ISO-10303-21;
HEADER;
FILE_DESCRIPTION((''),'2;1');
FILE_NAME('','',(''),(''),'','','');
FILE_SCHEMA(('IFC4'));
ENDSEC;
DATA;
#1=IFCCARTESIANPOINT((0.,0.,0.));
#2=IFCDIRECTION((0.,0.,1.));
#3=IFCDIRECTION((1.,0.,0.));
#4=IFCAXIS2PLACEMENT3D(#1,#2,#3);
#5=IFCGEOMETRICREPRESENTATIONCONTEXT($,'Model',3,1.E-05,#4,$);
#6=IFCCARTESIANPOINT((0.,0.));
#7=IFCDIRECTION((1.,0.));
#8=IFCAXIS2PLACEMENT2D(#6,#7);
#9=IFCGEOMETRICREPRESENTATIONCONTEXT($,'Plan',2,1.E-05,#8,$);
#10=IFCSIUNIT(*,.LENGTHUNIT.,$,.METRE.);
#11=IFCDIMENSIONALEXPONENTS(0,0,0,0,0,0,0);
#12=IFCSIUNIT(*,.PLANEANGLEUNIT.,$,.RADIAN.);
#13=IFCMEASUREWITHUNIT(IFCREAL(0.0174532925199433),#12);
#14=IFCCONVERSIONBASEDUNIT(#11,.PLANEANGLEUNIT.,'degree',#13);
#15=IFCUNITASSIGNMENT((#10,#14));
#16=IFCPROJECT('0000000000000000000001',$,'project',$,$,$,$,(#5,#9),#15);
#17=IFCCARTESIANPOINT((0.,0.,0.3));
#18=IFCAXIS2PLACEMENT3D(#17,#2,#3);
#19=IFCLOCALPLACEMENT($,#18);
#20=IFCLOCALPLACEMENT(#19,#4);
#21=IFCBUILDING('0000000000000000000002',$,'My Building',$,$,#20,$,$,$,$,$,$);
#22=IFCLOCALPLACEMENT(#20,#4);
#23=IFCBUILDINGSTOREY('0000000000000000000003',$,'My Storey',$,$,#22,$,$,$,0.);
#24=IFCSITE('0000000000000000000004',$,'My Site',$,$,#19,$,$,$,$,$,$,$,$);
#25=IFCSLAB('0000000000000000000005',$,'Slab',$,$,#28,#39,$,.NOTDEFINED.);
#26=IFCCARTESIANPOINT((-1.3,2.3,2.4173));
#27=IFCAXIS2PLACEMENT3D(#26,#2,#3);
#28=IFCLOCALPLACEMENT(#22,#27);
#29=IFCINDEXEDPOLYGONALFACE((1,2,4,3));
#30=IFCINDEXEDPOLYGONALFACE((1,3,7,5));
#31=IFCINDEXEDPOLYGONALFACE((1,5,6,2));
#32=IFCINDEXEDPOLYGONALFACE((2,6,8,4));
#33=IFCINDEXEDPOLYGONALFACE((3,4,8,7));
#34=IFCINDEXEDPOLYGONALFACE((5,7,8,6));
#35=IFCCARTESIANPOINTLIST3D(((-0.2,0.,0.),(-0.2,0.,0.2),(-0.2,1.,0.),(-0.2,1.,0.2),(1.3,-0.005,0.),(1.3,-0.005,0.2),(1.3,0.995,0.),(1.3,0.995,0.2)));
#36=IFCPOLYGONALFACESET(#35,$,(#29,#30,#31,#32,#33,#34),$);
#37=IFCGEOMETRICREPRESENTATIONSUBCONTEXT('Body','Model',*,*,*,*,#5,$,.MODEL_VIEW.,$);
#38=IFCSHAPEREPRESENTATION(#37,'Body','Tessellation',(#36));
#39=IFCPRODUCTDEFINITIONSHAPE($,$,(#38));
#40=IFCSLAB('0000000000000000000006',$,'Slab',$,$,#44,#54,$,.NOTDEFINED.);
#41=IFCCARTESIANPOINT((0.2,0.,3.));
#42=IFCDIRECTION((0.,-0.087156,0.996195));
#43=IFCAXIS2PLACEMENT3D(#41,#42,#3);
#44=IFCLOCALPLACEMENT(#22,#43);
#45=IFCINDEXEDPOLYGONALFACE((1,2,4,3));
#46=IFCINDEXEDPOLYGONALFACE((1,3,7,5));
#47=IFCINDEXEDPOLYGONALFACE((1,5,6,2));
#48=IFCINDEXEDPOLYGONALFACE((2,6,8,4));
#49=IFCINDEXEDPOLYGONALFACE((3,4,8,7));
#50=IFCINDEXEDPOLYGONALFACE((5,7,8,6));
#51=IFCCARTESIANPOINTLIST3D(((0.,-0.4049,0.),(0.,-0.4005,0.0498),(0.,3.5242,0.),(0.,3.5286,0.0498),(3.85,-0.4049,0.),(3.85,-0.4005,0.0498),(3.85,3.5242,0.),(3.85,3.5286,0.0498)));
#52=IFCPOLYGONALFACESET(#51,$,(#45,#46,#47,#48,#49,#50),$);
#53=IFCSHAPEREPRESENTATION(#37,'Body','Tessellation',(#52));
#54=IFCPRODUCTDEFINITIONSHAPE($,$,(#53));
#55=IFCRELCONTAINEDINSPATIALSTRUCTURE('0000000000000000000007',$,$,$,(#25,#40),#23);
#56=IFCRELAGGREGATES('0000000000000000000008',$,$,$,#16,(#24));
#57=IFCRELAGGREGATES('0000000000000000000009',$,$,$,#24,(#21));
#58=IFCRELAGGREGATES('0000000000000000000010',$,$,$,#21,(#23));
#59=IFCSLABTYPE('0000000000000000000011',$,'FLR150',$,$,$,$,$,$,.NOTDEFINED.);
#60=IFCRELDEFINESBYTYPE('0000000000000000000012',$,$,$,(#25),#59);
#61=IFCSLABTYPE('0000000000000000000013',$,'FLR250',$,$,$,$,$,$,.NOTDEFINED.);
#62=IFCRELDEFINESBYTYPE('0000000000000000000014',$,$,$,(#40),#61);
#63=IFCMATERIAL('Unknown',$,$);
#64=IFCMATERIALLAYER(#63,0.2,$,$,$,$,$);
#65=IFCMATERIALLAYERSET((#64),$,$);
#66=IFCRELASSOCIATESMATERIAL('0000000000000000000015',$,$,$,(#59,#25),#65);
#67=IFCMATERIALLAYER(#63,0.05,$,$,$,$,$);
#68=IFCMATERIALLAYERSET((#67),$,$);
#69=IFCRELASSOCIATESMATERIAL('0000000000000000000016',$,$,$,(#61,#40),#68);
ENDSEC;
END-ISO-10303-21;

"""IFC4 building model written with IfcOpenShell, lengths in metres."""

from ifc_helpers import new_model, entity, si_unit, converted_unit, frame, origin_with_axes, origin_2d_with_axis, place, context, subcontext, project, spatial, line, indexed_curve, outline, extrude, material, layer, layer_set, layer_usage, type_object, element, save


model = new_model("IFC4")

# Units and contexts
model_context = context("Model", 3, precision=1e-05, world=origin_with_axes())
plan_context = context("Plan", 2, precision=1e-05, world=origin_2d_with_axis())
body_context = subcontext(model_context, "Body", "Model", "MODEL_VIEW")
ifc_project = project(units=[si_unit("LENGTHUNIT", "METRE"), converted_unit("PLANEANGLEUNIT", "degree", entity("IfcReal", 0.0174532925199433), si_unit("PLANEANGLEUNIT", "RADIAN"), dimensions=[0, 0, 0, 0, 0, 0, 0])], contexts=[model_context, plan_context])

# Site, building, storey
site_placement = place(None, frame((0.0, 0.0, 0.3), z_axis=(0.0, 0.0, 1.0), x_axis=(1.0, 0.0, 0.0)))
site = spatial("IfcSite", under=ifc_project, at=site_placement, Name="My Site")
building_placement = place(site_placement, origin_with_axes())
building = spatial("IfcBuilding", under=site, at=building_placement, Name="My Building")
storey_placement = place(building_placement, origin_with_axes())
storey = spatial("IfcBuildingStorey", under=building, at=storey_placement, Name="My Storey", Elevation=0.0)

# Shared definitions
ifc_material = material(Name="Unknown")

# Slabs
ifc_layer_1 = layer(ifc_material, 0.2)
ifc_layer_set_1 = layer_set([ifc_layer_1])
slab_type_1 = type_object("IfcSlabType", Name="FLR150", PredefinedType="NOTDEFINED", material=ifc_layer_set_1)
ifc_layer_usage_1 = layer_usage(ifc_layer_set_1, "AXIS3", "POSITIVE", 0.0)
slab_1_placement = place(storey_placement, frame((-1.3, 2.3, 2.4173), z_axis=(0.0, 0.0, 1.0), x_axis=(1.0, 0.0, 0.0)))
element("IfcSlab", 1, at=slab_1_placement, inside=storey, type_object=slab_type_1, material=ifc_layer_usage_1, Name="Slab", PredefinedType="NOTDEFINED", context=body_context, shape_type="SweptSolid", body=[
    extrude(outline(indexed_curve([(-0.2, 1.0), (-0.2, 0.0), (1.3, -0.005), (1.3, 0.995)], segments=[line(3, 2), line(2, 1), line(1, 4), line(4, 3)], self_intersect=False)), None, (0.0, 0.0, 1.0), 0.2),
])
ifc_layer_2 = layer(ifc_material, 0.05)
ifc_layer_set_2 = layer_set([ifc_layer_2])
ifc_layer_usage_2 = layer_usage(ifc_layer_set_2, "AXIS3", "POSITIVE", 0.0)
slab_type_2 = type_object("IfcSlabType", Name="FLR250", PredefinedType="NOTDEFINED", material=ifc_layer_set_2)
slab_2_placement = place(storey_placement, frame((0.2, 0.0, 3.0), z_axis=(0.0, -0.087156, 0.996195), x_axis=(1.0, 0.0, 0.0)))
element("IfcSlab", 2, at=slab_2_placement, inside=storey, type_object=slab_type_2, material=ifc_layer_usage_2, Name="Slab", PredefinedType="NOTDEFINED", context=body_context, shape_type="SweptSolid", body=[
    extrude(outline(indexed_curve([(0.0, 3.5242), (3.85, 3.5242), (3.85, -0.4049), (0.0, -0.4049)], segments=[line(3, 2), line(2, 1), line(1, 4), line(4, 3)], self_intersect=False)), None, (0.0, 0.087156, 0.996195), 0.05),
])

save(model, "model.ifc")
